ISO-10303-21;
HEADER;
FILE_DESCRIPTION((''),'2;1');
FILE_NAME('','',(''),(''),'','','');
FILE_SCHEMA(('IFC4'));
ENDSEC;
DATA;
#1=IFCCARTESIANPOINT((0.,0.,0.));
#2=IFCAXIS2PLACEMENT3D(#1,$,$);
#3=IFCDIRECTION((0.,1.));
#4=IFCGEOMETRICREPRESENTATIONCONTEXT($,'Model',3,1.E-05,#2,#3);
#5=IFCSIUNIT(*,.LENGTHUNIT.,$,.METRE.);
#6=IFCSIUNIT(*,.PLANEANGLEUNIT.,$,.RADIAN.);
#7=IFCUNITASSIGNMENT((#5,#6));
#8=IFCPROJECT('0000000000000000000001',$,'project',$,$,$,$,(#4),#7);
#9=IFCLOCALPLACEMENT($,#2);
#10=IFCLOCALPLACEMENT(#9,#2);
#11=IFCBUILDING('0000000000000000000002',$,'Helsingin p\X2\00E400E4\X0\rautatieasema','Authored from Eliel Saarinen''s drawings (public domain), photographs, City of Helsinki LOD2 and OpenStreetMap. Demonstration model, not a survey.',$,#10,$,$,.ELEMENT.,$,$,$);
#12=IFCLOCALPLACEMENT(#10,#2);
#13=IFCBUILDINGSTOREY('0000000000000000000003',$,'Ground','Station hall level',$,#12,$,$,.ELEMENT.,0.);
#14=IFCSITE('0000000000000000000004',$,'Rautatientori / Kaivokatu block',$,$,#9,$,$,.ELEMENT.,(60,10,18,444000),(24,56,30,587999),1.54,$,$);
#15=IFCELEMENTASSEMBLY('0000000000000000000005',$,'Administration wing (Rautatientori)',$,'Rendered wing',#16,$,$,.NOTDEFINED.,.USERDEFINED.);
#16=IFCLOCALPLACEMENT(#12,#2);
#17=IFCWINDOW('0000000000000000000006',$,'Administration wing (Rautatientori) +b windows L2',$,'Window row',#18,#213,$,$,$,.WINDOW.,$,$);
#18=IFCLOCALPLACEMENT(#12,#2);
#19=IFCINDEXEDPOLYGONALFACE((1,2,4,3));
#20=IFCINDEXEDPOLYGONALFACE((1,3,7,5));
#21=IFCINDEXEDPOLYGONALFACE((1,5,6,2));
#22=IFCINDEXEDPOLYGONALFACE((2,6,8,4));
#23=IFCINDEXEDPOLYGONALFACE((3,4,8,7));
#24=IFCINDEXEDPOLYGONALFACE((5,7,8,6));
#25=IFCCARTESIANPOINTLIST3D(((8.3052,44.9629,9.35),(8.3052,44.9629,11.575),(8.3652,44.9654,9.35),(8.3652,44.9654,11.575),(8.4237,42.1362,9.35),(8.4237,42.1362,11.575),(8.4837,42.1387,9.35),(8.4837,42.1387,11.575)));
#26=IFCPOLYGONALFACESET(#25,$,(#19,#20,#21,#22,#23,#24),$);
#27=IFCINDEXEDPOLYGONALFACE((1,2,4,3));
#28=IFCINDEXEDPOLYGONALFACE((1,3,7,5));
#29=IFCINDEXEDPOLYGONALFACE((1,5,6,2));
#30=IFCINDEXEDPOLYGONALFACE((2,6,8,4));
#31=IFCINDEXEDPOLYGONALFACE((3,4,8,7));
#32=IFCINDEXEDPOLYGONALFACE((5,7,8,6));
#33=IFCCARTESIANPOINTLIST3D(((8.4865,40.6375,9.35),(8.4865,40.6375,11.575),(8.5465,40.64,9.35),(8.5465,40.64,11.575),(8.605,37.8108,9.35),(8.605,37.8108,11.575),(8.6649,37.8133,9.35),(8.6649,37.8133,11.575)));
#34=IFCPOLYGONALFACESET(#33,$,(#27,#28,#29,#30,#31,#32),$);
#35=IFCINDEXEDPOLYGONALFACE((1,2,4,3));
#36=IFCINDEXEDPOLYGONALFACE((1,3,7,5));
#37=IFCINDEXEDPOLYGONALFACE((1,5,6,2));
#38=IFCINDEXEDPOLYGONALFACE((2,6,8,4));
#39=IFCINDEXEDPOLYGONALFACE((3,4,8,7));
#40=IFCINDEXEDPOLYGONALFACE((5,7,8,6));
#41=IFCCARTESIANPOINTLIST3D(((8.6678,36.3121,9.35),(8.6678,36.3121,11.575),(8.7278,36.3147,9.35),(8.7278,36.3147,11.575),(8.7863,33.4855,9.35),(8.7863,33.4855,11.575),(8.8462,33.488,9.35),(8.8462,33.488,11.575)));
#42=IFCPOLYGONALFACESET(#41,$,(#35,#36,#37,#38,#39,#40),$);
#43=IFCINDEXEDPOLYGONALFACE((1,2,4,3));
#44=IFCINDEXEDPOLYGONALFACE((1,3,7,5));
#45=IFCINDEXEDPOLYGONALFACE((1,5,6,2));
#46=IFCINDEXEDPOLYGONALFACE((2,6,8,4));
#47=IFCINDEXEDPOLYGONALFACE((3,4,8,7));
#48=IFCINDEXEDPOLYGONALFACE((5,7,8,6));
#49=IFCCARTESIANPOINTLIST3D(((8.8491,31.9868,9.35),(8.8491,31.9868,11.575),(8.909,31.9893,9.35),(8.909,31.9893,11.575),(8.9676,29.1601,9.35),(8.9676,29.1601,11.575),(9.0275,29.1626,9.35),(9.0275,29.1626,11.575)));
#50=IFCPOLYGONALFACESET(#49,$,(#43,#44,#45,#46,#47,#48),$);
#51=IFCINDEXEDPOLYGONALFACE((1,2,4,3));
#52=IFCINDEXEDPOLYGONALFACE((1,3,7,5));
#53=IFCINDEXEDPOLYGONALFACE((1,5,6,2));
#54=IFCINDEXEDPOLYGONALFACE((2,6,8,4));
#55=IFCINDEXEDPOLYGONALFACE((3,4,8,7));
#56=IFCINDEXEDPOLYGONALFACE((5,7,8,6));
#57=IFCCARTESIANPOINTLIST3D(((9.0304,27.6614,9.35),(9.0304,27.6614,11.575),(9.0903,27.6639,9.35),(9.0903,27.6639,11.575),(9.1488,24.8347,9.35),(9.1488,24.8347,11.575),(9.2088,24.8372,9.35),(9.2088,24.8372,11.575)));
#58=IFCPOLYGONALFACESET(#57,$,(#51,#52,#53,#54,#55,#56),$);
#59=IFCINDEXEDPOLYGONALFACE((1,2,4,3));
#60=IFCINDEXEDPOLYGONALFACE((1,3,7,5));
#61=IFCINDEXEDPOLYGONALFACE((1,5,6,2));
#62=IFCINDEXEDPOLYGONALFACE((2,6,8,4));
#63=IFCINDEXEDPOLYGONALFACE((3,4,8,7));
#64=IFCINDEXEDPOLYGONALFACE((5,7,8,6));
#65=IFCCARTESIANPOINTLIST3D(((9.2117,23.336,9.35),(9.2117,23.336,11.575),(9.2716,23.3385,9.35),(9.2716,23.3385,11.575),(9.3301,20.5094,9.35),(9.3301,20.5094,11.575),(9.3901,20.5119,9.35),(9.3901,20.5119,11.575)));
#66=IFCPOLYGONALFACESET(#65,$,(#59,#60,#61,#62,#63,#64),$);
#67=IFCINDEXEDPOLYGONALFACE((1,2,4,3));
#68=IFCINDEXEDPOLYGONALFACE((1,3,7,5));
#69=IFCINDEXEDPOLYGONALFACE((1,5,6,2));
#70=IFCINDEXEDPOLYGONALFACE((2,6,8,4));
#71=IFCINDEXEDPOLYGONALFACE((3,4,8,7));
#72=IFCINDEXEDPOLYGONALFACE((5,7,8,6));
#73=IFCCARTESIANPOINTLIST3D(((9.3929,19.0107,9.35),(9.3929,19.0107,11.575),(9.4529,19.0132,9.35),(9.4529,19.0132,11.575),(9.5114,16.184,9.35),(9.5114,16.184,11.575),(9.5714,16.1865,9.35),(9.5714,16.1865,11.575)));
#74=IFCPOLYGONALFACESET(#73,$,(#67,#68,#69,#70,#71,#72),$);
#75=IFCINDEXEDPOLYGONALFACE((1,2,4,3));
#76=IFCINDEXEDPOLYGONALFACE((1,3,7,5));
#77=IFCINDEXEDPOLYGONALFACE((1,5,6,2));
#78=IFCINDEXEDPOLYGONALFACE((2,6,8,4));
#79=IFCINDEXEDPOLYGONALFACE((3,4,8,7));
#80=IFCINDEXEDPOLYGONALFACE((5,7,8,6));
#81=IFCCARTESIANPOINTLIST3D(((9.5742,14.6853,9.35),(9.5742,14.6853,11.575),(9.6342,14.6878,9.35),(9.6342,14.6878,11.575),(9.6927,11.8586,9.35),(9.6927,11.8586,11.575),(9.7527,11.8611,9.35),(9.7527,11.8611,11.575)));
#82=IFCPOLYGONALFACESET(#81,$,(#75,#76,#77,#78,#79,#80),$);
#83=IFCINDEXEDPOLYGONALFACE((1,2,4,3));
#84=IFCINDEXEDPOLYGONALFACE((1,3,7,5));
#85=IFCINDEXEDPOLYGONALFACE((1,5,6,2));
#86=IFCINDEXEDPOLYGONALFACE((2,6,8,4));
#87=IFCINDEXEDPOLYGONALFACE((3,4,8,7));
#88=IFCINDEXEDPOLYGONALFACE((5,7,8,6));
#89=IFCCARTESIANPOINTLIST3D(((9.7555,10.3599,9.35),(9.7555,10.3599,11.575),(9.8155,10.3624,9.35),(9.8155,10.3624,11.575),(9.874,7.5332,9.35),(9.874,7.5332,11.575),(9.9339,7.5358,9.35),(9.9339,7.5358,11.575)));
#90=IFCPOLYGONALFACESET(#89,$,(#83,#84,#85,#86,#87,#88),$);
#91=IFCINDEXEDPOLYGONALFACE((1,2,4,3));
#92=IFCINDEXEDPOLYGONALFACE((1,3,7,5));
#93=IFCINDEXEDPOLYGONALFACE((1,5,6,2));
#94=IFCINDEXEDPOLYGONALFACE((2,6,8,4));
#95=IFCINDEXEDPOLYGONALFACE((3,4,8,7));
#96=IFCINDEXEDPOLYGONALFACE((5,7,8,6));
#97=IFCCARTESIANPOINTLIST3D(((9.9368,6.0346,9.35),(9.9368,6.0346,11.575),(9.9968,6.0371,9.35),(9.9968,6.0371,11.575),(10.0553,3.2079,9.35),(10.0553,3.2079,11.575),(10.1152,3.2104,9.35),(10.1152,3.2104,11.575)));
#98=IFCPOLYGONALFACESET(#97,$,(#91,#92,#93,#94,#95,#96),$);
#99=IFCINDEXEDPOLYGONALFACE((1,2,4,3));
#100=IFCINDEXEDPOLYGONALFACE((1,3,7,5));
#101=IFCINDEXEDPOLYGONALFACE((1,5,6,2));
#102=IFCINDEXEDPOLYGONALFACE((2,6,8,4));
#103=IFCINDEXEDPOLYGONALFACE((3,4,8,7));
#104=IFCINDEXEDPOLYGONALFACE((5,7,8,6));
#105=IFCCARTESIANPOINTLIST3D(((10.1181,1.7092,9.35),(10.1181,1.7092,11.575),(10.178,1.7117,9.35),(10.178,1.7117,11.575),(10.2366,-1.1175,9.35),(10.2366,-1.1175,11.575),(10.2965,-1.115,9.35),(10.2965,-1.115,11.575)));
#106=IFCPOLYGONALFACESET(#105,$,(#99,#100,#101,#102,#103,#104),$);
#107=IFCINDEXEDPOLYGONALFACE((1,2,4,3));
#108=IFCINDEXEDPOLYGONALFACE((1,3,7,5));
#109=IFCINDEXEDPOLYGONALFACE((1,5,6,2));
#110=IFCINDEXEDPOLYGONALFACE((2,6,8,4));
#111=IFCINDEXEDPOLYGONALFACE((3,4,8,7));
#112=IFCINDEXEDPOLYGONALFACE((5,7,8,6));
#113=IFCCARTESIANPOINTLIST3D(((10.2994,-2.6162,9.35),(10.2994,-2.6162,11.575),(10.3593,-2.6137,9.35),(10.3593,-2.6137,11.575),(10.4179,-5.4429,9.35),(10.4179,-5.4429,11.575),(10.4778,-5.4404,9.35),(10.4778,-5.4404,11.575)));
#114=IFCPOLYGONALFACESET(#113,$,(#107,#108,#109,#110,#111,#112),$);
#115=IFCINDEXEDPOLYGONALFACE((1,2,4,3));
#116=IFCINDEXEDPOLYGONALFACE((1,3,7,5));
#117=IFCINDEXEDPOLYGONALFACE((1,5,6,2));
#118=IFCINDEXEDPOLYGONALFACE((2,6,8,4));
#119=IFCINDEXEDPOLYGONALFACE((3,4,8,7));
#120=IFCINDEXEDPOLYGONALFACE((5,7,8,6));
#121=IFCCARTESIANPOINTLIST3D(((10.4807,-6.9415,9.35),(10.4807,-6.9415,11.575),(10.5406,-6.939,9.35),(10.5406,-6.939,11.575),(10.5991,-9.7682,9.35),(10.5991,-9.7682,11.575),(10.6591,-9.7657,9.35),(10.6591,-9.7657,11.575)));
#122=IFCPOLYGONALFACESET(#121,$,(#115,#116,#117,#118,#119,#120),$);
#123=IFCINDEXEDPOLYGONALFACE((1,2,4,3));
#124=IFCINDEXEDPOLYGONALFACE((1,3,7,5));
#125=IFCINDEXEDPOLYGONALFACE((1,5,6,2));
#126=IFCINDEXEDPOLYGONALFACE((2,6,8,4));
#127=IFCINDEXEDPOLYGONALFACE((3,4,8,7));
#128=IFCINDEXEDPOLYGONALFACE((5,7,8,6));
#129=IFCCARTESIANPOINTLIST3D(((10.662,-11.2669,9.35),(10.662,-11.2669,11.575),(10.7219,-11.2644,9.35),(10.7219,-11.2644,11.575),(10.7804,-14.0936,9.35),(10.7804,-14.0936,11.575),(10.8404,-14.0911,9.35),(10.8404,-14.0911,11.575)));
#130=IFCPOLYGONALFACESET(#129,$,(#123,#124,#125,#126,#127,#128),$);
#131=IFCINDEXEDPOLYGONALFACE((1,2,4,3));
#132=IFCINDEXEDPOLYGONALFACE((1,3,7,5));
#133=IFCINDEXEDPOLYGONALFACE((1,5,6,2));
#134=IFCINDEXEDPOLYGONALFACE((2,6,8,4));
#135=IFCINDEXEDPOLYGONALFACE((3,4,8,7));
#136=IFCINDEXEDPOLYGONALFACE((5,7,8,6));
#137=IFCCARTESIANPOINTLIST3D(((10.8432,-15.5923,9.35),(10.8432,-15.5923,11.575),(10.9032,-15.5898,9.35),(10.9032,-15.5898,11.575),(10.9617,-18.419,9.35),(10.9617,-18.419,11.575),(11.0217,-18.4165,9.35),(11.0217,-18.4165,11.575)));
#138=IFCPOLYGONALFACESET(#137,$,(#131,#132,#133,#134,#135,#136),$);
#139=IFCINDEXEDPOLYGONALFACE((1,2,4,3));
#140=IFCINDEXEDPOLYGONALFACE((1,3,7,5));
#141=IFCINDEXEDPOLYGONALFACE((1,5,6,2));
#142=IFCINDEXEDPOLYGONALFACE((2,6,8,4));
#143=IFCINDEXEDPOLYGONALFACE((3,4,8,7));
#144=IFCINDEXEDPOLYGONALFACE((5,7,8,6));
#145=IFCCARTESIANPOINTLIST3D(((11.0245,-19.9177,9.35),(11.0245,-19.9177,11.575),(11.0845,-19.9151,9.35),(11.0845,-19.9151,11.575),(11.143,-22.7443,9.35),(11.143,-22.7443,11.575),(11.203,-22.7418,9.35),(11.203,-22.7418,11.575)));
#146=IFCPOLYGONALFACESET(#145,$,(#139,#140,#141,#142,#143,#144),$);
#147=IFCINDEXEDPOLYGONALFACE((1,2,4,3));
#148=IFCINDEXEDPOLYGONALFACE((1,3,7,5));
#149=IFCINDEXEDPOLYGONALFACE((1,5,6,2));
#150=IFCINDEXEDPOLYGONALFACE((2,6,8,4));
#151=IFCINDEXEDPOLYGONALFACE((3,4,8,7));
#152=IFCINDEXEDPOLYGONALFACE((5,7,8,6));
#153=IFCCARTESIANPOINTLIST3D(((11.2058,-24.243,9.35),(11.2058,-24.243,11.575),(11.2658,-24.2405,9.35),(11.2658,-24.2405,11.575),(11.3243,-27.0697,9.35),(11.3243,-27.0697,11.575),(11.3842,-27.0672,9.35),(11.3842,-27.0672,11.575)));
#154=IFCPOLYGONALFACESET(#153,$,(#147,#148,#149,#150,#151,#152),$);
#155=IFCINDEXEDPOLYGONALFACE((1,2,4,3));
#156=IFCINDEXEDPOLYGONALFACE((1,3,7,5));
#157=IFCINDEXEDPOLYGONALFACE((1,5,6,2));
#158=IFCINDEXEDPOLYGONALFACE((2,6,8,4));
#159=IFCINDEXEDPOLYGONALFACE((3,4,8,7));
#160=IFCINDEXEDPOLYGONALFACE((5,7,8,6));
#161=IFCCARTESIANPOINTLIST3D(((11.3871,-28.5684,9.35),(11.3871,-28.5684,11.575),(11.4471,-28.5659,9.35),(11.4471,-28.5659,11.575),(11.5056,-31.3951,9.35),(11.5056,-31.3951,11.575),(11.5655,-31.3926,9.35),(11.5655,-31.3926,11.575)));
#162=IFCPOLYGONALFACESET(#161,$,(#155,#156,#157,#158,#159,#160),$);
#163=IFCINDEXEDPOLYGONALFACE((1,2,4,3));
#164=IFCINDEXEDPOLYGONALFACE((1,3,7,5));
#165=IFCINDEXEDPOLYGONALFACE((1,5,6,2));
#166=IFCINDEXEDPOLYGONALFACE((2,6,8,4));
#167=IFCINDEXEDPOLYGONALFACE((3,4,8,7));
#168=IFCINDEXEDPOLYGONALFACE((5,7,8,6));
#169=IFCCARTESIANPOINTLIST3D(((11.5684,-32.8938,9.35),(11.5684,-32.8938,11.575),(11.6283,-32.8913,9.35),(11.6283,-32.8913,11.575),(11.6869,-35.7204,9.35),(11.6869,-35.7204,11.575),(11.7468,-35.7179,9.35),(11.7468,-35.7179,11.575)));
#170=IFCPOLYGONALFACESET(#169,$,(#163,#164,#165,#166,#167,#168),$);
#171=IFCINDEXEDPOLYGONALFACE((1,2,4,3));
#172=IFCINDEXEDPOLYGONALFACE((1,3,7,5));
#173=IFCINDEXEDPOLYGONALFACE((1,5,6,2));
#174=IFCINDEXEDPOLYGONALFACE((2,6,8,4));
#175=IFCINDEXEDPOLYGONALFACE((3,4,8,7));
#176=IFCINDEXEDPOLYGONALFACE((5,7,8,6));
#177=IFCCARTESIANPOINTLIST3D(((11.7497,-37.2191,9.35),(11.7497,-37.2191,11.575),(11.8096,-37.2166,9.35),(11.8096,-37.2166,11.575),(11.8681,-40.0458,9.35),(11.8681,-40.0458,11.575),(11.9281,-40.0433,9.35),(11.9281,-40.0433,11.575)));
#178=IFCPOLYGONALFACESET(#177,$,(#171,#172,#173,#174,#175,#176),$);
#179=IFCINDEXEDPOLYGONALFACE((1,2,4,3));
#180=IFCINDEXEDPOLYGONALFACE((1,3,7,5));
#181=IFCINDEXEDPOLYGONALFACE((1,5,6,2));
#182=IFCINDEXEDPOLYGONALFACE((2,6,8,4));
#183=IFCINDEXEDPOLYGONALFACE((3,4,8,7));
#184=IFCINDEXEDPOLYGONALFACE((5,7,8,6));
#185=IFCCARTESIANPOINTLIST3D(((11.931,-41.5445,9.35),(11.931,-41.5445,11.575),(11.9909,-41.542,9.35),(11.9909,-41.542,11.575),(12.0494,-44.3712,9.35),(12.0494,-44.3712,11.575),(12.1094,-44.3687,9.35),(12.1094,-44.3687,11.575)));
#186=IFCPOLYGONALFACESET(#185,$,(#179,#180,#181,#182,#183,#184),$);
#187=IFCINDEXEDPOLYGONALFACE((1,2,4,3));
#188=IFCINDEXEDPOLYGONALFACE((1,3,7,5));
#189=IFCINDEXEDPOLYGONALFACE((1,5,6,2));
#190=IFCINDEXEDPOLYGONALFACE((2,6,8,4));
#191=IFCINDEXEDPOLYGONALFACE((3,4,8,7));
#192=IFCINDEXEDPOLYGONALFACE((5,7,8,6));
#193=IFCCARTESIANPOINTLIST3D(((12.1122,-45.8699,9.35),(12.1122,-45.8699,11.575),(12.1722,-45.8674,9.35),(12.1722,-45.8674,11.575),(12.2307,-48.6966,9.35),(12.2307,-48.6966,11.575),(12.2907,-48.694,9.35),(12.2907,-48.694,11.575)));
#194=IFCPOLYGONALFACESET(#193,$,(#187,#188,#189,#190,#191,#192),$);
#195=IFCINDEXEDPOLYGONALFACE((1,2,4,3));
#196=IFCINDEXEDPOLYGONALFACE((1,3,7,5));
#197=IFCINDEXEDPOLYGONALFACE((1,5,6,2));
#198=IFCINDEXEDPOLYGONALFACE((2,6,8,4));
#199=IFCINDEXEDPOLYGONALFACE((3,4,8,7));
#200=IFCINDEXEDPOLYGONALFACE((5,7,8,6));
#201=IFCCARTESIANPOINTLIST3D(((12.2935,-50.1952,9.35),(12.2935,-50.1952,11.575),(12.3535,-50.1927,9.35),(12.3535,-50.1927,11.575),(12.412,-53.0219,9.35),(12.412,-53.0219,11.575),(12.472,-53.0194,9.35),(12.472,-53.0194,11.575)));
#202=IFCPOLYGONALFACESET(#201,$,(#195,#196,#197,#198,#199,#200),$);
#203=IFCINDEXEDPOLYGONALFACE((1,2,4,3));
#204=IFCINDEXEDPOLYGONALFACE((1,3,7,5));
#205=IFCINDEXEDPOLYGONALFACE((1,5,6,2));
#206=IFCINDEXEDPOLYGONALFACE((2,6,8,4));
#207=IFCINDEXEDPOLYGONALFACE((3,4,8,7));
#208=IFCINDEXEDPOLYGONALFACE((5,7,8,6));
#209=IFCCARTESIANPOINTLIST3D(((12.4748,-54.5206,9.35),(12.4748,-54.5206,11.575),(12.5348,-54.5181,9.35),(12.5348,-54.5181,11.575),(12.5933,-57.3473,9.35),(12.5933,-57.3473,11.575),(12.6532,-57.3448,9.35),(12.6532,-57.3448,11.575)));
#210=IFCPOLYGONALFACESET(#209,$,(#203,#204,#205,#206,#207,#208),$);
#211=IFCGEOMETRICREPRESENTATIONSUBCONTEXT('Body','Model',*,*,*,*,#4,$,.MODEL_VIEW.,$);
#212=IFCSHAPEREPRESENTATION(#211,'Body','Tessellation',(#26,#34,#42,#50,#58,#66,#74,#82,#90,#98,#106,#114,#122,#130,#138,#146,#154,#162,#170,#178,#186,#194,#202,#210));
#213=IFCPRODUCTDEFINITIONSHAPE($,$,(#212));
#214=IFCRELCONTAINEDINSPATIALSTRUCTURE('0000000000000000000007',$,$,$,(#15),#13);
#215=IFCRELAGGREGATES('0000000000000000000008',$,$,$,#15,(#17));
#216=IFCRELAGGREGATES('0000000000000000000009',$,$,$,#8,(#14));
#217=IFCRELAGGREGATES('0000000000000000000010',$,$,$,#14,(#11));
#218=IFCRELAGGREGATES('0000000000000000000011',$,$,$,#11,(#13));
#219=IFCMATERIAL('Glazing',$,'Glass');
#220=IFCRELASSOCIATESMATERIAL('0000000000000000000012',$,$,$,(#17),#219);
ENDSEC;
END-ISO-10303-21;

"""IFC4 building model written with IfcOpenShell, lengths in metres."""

from ifc_helpers import new_model, si_unit, direction, frame, frame_2d, origin, place, context, subcontext, project, spatial, rectangle, extrude, material, element, aggregate, save


model = new_model("IFC4")

# Units and contexts
model_context = context("Model", 3, precision=1e-05, world=origin(), true_north=direction((0.0, 1.0)))
body_context = subcontext(model_context, "Body", "Model", "MODEL_VIEW")
ifc_project = project(units=[si_unit("LENGTHUNIT", "METRE"), si_unit("PLANEANGLEUNIT", "RADIAN")], contexts=[model_context])

# Site, building, storey
site_placement = place(None, origin())
site = spatial("IfcSite", under=ifc_project, at=site_placement, Name="Rautatientori / Kaivokatu block", CompositionType="ELEMENT", RefLatitude=(60, 10, 18, 444000), RefLongitude=(24, 56, 30, 587999), RefElevation=1.54)
building_placement = place(site_placement, origin())
building = spatial("IfcBuilding", under=site, at=building_placement, Name="Helsingin päärautatieasema", Description="Authored from Eliel Saarinen's drawings (public domain), photographs, City of Helsinki LOD2 and OpenStreetMap. Demonstration model, not a survey.", CompositionType="ELEMENT")
storey_placement = place(building_placement, origin())
storey = spatial("IfcBuildingStorey", under=building, at=storey_placement, Name="Ground", Description="Station hall level", CompositionType="ELEMENT", Elevation=0.0)

# Element assembly, window
assembly_placement = place(building_placement, origin())
assembly = element("IfcElementAssembly", 1, at=assembly_placement, inside=storey, Name="Administration wing (Rautatientori)", ObjectType="Rendered wing", AssemblyPlace="NOTDEFINED", PredefinedType="USERDEFINED")
ifc_material_1 = material(Name="Glazing", Category="Glass")
window_1_placement = place(building_placement, origin())
window_1 = element("IfcWindow", 2, at=window_1_placement, material=ifc_material_1, Name="Administration wing (Rautatientori) +b windows L2", ObjectType="Window row", PredefinedType="WINDOW", context=body_context, shape_type="SweptSolid", body=[
    extrude(rectangle(XDim=2.8292, YDim=0.06, at=frame_2d((0.0, 0.0), x_axis=(0.041876, -0.999123))), frame((8.3944, 43.5508, 9.35)), (0.0, 0.0, 1.0), 2.225),
    extrude(rectangle(XDim=2.8292, YDim=0.06, at=frame_2d((0.0, 0.0), x_axis=(0.041876, -0.999123))), frame((8.5757, 39.2254, 9.35)), (0.0, 0.0, 1.0), 2.225),
    extrude(rectangle(XDim=2.8292, YDim=0.06, at=frame_2d((0.0, 0.0), x_axis=(0.041876, -0.999123))), frame((8.757, 34.9001, 9.35)), (0.0, 0.0, 1.0), 2.225),
    extrude(rectangle(XDim=2.8292, YDim=0.06, at=frame_2d((0.0, 0.0), x_axis=(0.041876, -0.999123))), frame((8.9383, 30.5747, 9.35)), (0.0, 0.0, 1.0), 2.225),
    extrude(rectangle(XDim=2.8292, YDim=0.06, at=frame_2d((0.0, 0.0), x_axis=(0.041876, -0.999123))), frame((9.1196, 26.2493, 9.35)), (0.0, 0.0, 1.0), 2.225),
    extrude(rectangle(XDim=2.8292, YDim=0.06, at=frame_2d((0.0, 0.0), x_axis=(0.041876, -0.999123))), frame((9.3009, 21.9239, 9.35)), (0.0, 0.0, 1.0), 2.225),
    extrude(rectangle(XDim=2.8292, YDim=0.06, at=frame_2d((0.0, 0.0), x_axis=(0.041876, -0.999123))), frame((9.4822, 17.5986, 9.35)), (0.0, 0.0, 1.0), 2.225),
    extrude(rectangle(XDim=2.8292, YDim=0.06, at=frame_2d((0.0, 0.0), x_axis=(0.041876, -0.999123))), frame((9.6634, 13.2732, 9.35)), (0.0, 0.0, 1.0), 2.225),
    extrude(rectangle(XDim=2.8292, YDim=0.06, at=frame_2d((0.0, 0.0), x_axis=(0.041876, -0.999123))), frame((9.8447, 8.9478, 9.35)), (0.0, 0.0, 1.0), 2.225),
    extrude(rectangle(XDim=2.8292, YDim=0.06, at=frame_2d((0.0, 0.0), x_axis=(0.041876, -0.999123))), frame((10.026, 4.6225, 9.35)), (0.0, 0.0, 1.0), 2.225),
    extrude(rectangle(XDim=2.8292, YDim=0.06, at=frame_2d((0.0, 0.0), x_axis=(0.041876, -0.999123))), frame((10.2073, 0.2971, 9.35)), (0.0, 0.0, 1.0), 2.225),
    extrude(rectangle(XDim=2.8292, YDim=0.06, at=frame_2d((0.0, 0.0), x_axis=(0.041876, -0.999123))), frame((10.3886, -4.0283, 9.35)), (0.0, 0.0, 1.0), 2.225),
    extrude(rectangle(XDim=2.8292, YDim=0.06, at=frame_2d((0.0, 0.0), x_axis=(0.041876, -0.999123))), frame((10.5699, -8.3536, 9.35)), (0.0, 0.0, 1.0), 2.225),
    extrude(rectangle(XDim=2.8292, YDim=0.06, at=frame_2d((0.0, 0.0), x_axis=(0.041876, -0.999123))), frame((10.7512, -12.679, 9.35)), (0.0, 0.0, 1.0), 2.225),
    extrude(rectangle(XDim=2.8292, YDim=0.06, at=frame_2d((0.0, 0.0), x_axis=(0.041876, -0.999123))), frame((10.9325, -17.0044, 9.35)), (0.0, 0.0, 1.0), 2.225),
    extrude(rectangle(XDim=2.8292, YDim=0.06, at=frame_2d((0.0, 0.0), x_axis=(0.041876, -0.999123))), frame((11.1137, -21.3297, 9.35)), (0.0, 0.0, 1.0), 2.225),
    extrude(rectangle(XDim=2.8292, YDim=0.06, at=frame_2d((0.0, 0.0), x_axis=(0.041876, -0.999123))), frame((11.295, -25.6551, 9.35)), (0.0, 0.0, 1.0), 2.225),
    extrude(rectangle(XDim=2.8292, YDim=0.06, at=frame_2d((0.0, 0.0), x_axis=(0.041876, -0.999123))), frame((11.4763, -29.9805, 9.35)), (0.0, 0.0, 1.0), 2.225),
    extrude(rectangle(XDim=2.8292, YDim=0.06, at=frame_2d((0.0, 0.0), x_axis=(0.041876, -0.999123))), frame((11.6576, -34.3059, 9.35)), (0.0, 0.0, 1.0), 2.225),
    extrude(rectangle(XDim=2.8292, YDim=0.06, at=frame_2d((0.0, 0.0), x_axis=(0.041876, -0.999123))), frame((11.8389, -38.6312, 9.35)), (0.0, 0.0, 1.0), 2.225),
    extrude(rectangle(XDim=2.8292, YDim=0.06, at=frame_2d((0.0, 0.0), x_axis=(0.041876, -0.999123))), frame((12.0202, -42.9566, 9.35)), (0.0, 0.0, 1.0), 2.225),
    extrude(rectangle(XDim=2.8292, YDim=0.06, at=frame_2d((0.0, 0.0), x_axis=(0.041876, -0.999123))), frame((12.2015, -47.282, 9.35)), (0.0, 0.0, 1.0), 2.225),
    extrude(rectangle(XDim=2.8292, YDim=0.06, at=frame_2d((0.0, 0.0), x_axis=(0.041876, -0.999123))), frame((12.3827, -51.6073, 9.35)), (0.0, 0.0, 1.0), 2.225),
    extrude(rectangle(XDim=2.8292, YDim=0.06, at=frame_2d((0.0, 0.0), x_axis=(0.041876, -0.999123))), frame((12.564, -55.9327, 9.35)), (0.0, 0.0, 1.0), 2.225),
])
aggregate(assembly, [window_1])

save(model, "model.ifc")
